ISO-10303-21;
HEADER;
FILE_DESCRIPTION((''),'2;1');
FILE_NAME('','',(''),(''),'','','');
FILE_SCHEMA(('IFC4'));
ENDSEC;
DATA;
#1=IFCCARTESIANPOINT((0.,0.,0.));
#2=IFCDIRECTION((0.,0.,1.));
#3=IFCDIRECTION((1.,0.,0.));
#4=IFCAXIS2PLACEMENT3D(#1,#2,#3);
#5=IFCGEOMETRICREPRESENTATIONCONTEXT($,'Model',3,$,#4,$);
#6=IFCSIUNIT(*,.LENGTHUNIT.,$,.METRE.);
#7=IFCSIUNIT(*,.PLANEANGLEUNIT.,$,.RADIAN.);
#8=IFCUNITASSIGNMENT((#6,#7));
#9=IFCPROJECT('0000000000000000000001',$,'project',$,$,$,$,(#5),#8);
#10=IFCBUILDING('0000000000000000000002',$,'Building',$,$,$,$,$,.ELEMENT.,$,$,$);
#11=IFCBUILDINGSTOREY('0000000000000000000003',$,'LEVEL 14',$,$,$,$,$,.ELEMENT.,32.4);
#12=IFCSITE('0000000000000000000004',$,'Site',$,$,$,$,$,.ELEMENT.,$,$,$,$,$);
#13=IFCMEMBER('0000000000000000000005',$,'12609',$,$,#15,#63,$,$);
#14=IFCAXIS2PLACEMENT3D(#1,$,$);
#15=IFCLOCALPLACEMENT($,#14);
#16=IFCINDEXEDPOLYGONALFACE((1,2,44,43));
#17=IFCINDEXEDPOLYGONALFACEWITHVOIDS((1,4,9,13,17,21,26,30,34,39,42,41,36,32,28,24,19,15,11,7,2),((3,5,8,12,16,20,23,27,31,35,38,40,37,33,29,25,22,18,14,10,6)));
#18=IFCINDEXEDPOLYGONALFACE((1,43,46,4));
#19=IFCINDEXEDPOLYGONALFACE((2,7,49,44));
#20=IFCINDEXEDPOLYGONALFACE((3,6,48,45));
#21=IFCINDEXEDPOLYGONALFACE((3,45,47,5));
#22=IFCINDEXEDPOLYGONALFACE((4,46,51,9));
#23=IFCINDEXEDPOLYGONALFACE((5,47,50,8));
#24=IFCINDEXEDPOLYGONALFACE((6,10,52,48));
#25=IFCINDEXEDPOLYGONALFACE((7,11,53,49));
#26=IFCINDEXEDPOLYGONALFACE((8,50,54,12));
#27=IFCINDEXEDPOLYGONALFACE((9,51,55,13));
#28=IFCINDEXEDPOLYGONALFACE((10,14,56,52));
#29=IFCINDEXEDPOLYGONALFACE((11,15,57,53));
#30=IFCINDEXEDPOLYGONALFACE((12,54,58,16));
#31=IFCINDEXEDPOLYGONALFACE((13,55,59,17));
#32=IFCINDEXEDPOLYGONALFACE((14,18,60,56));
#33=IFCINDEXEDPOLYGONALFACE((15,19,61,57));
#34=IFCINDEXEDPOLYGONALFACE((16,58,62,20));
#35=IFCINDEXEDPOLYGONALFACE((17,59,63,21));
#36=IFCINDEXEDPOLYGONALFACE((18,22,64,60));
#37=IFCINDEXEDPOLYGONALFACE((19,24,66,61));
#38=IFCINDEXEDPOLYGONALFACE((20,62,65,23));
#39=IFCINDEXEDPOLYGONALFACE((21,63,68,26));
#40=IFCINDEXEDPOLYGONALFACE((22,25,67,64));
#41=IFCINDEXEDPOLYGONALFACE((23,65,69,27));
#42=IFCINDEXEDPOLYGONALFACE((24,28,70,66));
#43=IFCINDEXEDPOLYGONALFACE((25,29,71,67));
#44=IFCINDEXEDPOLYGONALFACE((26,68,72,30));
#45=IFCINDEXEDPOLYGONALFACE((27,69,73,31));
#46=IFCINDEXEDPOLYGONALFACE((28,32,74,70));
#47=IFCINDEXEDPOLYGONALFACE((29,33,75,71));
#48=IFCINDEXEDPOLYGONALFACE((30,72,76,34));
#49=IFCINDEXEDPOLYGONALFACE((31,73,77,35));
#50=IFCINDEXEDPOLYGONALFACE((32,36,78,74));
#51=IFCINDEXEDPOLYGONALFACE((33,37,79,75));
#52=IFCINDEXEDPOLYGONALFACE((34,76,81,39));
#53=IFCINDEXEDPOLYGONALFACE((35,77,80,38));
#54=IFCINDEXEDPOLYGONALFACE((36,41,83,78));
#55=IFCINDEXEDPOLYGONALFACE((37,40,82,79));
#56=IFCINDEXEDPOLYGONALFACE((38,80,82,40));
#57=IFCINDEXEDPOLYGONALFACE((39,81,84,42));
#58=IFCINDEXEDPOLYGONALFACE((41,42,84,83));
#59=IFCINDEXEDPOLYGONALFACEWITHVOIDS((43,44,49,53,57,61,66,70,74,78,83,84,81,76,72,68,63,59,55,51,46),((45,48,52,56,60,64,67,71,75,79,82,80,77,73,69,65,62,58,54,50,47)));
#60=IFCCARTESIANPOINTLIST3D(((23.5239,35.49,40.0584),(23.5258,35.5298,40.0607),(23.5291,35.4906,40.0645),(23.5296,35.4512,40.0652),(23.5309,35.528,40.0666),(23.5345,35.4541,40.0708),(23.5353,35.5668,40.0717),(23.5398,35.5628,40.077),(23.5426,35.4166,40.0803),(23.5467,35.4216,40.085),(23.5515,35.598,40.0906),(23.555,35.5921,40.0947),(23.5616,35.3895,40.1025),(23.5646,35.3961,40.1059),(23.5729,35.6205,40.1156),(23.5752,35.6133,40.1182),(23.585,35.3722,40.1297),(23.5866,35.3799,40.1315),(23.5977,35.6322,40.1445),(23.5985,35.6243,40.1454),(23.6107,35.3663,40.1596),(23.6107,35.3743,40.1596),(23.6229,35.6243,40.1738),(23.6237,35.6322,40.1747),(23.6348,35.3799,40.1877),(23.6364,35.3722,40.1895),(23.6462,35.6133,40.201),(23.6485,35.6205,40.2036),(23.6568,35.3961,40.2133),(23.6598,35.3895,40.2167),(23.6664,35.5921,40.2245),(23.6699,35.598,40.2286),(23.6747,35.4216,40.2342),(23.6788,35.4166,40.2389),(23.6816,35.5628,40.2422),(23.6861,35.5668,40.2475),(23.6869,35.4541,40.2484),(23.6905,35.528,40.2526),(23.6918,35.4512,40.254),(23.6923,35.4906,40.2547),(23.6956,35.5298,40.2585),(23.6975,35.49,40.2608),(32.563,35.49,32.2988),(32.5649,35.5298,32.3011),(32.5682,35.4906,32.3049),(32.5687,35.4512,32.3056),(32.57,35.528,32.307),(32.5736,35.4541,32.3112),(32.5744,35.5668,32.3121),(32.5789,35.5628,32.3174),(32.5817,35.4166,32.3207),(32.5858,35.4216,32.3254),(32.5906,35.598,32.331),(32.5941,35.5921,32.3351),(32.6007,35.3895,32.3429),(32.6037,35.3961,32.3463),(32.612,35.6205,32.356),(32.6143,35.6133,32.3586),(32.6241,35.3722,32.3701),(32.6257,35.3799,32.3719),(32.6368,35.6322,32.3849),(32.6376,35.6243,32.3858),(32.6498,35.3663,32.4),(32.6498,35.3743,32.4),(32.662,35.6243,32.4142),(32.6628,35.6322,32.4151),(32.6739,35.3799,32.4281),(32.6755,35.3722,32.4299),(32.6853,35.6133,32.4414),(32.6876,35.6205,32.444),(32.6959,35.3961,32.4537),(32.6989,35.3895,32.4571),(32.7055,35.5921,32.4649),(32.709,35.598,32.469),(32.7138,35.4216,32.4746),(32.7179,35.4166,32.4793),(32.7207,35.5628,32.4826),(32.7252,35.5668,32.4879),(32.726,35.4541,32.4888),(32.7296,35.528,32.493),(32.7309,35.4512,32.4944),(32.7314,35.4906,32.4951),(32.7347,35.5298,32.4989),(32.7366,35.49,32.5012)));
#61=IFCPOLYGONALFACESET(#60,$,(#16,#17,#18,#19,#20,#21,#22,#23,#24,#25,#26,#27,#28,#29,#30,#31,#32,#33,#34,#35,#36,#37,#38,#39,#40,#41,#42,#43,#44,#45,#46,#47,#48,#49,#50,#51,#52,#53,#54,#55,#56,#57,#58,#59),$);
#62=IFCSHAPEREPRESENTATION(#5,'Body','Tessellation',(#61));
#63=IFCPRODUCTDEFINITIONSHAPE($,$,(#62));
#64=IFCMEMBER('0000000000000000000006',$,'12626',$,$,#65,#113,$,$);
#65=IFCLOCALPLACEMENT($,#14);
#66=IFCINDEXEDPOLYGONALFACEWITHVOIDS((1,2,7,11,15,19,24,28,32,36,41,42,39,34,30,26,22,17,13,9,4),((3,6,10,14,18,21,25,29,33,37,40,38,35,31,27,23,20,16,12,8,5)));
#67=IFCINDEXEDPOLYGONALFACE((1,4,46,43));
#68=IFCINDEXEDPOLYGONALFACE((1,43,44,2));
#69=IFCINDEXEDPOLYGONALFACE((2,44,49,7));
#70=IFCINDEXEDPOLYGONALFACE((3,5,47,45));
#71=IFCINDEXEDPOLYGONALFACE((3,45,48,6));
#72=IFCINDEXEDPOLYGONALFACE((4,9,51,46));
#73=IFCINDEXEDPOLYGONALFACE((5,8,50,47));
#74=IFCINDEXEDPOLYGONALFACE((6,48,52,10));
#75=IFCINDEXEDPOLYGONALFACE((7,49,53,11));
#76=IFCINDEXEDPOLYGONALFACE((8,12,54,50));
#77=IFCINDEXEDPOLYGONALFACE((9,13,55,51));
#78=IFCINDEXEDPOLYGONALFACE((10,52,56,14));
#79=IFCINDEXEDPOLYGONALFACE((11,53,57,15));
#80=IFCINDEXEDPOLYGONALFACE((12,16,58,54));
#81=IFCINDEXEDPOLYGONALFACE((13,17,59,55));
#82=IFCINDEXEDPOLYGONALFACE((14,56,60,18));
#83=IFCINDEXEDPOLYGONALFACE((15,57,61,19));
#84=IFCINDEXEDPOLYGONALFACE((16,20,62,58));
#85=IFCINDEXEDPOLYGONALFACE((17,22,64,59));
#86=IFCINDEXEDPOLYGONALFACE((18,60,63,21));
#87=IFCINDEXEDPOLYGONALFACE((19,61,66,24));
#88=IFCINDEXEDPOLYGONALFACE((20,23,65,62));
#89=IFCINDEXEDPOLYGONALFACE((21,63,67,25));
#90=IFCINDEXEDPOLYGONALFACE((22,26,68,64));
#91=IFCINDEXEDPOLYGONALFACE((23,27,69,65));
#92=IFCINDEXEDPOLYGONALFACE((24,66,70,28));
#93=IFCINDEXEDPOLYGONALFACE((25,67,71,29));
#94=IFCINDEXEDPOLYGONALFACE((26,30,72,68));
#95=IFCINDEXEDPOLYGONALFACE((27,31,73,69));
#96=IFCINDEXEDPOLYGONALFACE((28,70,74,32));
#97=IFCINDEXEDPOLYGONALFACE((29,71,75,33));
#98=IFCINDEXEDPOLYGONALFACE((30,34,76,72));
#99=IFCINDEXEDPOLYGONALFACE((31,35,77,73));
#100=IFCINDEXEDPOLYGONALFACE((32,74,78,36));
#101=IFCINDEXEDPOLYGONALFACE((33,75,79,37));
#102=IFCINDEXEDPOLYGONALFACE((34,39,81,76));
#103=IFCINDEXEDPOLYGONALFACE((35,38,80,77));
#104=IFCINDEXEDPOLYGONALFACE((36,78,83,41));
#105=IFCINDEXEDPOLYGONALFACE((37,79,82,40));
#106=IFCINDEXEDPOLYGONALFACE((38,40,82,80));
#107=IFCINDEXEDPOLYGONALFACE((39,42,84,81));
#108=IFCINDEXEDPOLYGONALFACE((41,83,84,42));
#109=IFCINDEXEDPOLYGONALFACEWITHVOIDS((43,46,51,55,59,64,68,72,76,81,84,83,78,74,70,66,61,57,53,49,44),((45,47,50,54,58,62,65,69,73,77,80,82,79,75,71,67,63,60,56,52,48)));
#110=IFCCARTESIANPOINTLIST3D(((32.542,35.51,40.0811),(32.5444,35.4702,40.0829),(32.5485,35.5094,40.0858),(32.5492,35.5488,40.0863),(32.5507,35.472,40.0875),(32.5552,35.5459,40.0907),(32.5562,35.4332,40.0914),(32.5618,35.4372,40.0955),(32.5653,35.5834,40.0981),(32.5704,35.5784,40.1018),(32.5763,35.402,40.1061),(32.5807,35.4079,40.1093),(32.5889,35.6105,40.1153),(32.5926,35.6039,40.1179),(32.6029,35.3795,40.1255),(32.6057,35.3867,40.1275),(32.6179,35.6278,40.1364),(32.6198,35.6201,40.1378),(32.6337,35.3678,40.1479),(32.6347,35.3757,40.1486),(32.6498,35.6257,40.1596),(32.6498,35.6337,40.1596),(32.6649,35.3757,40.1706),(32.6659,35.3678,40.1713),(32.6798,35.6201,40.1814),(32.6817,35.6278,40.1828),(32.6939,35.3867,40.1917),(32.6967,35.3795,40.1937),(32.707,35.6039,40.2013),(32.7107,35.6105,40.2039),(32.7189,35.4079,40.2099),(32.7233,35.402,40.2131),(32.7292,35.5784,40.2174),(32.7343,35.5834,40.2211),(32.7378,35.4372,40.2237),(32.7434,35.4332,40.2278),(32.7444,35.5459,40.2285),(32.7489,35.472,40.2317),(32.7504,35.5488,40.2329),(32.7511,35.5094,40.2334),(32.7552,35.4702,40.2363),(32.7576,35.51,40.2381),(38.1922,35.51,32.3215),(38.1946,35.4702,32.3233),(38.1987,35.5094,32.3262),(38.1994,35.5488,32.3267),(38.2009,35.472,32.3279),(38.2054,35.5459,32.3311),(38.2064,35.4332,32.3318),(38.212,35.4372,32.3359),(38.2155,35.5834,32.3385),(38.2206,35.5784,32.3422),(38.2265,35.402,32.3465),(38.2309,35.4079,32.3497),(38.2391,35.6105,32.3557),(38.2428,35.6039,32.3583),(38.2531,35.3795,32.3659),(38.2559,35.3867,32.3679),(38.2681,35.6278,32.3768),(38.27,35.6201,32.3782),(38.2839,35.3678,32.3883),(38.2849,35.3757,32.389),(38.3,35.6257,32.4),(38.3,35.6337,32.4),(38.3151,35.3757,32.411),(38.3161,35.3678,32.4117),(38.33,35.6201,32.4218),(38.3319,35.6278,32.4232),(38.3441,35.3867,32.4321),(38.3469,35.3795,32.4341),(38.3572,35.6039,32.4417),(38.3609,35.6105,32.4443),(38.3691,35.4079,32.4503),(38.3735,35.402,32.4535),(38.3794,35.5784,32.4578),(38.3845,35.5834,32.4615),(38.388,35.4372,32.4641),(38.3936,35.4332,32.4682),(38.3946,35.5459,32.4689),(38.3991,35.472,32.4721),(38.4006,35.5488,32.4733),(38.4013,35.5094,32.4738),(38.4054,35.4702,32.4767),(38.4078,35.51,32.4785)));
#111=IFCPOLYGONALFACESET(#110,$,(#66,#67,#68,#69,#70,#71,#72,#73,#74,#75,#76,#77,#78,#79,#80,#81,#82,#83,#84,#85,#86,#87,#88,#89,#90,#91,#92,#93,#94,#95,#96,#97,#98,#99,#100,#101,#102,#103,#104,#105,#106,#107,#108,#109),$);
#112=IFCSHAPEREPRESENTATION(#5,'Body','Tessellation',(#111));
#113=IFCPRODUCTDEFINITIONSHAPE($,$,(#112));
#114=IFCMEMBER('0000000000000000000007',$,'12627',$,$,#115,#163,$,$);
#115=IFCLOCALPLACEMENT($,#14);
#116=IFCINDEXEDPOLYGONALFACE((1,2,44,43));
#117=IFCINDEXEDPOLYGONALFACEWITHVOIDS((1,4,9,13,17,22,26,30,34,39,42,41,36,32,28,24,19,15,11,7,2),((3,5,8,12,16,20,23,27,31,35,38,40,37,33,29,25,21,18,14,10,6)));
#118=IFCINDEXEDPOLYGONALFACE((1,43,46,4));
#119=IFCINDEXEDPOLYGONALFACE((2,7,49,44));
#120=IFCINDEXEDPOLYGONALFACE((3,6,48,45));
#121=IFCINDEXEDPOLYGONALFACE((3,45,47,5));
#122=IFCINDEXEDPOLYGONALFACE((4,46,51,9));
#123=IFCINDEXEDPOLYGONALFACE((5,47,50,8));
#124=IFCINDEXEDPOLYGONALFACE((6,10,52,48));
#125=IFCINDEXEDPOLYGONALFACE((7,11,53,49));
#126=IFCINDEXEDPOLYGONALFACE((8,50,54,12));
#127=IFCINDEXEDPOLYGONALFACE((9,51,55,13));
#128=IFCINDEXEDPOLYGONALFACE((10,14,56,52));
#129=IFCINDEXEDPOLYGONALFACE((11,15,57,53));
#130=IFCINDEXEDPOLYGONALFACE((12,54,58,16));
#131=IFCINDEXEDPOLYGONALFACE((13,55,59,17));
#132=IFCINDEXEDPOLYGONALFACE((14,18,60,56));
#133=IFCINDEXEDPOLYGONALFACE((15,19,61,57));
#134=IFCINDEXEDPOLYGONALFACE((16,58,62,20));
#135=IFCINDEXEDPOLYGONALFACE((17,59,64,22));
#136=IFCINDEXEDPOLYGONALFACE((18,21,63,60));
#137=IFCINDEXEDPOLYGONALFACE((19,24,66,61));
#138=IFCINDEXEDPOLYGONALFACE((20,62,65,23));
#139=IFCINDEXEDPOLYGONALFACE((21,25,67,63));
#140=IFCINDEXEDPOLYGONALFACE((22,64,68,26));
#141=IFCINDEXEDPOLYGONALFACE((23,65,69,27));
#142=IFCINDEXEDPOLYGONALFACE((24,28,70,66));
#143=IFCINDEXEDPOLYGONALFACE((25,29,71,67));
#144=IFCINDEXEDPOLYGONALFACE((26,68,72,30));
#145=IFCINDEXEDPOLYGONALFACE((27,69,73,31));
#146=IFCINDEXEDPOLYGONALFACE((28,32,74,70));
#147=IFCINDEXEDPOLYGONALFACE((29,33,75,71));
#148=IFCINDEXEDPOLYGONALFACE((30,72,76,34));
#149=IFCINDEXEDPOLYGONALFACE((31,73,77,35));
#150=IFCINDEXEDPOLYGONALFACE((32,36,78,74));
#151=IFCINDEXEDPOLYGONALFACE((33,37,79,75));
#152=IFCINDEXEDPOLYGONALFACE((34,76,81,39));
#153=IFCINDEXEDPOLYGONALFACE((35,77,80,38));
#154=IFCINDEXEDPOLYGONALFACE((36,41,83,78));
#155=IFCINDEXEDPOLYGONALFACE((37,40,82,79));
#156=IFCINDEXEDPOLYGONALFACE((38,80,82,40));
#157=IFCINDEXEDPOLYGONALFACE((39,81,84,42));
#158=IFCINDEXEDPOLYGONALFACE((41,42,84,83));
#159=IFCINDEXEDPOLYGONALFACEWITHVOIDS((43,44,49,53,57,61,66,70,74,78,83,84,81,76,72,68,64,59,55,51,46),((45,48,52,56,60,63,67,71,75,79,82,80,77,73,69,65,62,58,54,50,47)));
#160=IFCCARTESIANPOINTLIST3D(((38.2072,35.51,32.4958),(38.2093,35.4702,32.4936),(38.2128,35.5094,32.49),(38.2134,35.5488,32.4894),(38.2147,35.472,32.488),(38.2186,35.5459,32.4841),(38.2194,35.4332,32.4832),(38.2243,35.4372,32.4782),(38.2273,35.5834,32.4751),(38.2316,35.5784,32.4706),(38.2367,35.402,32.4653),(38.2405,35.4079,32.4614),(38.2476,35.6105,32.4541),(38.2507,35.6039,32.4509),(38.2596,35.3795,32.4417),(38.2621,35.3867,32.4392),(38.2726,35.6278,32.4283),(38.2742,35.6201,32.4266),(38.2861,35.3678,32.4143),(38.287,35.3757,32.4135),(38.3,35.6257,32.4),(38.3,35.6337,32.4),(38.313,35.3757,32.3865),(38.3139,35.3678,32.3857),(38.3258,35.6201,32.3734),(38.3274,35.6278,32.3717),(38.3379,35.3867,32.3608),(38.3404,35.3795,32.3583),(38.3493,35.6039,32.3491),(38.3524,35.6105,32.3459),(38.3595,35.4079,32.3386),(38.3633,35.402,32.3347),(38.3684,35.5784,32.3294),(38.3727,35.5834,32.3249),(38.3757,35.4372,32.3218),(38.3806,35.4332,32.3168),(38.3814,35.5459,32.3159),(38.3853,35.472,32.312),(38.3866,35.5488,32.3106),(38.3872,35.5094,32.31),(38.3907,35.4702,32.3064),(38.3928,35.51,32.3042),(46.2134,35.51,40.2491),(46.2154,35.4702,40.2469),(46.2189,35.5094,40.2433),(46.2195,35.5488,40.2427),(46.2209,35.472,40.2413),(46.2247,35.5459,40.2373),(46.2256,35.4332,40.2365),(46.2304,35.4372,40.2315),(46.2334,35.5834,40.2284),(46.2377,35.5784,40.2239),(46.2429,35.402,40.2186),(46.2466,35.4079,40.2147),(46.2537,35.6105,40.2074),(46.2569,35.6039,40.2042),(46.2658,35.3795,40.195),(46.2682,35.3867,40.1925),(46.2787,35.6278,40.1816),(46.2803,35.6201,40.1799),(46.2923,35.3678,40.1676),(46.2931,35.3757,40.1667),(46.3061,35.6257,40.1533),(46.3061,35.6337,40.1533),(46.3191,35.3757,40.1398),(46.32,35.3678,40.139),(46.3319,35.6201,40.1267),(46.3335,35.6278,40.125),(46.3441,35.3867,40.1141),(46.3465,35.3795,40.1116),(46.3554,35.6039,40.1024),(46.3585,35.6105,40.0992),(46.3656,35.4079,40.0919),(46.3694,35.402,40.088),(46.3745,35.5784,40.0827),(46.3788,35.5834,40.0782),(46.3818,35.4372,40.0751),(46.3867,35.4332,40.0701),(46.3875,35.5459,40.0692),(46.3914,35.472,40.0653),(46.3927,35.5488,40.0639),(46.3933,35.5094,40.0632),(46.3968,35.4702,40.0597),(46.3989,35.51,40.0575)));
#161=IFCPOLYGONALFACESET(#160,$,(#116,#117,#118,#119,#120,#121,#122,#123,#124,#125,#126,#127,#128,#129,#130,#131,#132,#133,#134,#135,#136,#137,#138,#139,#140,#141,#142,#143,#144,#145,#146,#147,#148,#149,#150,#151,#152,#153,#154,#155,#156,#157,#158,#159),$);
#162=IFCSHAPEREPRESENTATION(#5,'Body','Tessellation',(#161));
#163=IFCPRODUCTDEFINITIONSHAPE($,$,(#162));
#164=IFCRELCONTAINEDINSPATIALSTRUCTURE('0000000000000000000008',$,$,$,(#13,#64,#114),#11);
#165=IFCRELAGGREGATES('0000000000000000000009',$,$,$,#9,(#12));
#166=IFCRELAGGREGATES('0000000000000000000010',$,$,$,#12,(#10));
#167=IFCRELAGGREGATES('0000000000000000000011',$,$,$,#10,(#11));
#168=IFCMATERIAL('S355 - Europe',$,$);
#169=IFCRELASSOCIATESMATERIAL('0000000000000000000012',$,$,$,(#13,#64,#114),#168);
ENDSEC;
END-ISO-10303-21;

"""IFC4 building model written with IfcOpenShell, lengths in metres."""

from ifc_helpers import new_model, si_unit, frame, origin_with_axes, origin_2d_with_axis, place, context, project, spatial, hollow_circle, extrude, material, material_profile, profile_set, profile_usage, element, save


model = new_model("IFC4")

# Units and contexts
model_context = context("Model", 3, world=origin_with_axes())
ifc_project = project(units=[si_unit("LENGTHUNIT", "METRE"), si_unit("PLANEANGLEUNIT", "RADIAN")], contexts=[model_context])

# Site, building, storey
site = spatial("IfcSite", under=ifc_project, Name="Site", CompositionType="ELEMENT")
building = spatial("IfcBuilding", under=site, Name="Building", CompositionType="ELEMENT")
storey = spatial("IfcBuildingStorey", under=building, Name="LEVEL 14", CompositionType="ELEMENT", Elevation=32.4)

# Shared definitions
ifc_material = material(Name="S355 - Europe")

# Members
ifc_material_profile_1 = material_profile(ifc_material, hollow_circle(Radius=0.1337, WallThickness=0.008, at=origin_2d_with_axis()))
ifc_profile_set_1 = profile_set([ifc_material_profile_1])
ifc_profile_usage_1 = profile_usage(ifc_profile_set_1, cardinal=10)
member_1_placement = place(None, frame((32.6498, 35.5, 32.4), z_axis=(-0.758767, 0.0, 0.651362), x_axis=(0.0, -1.0, 0.0)))
element("IfcMember", 1, at=member_1_placement, inside=storey, material=ifc_profile_usage_1, Name="12609", context=model_context, shape_type="SweptSolid", body=[
    extrude(hollow_circle(Radius=0.1337, WallThickness=0.008, at=origin_2d_with_axis()), origin_with_axes(), (0.0, 0.0, 1.0), 11.9129),
])
ifc_material_profile_2 = material_profile(ifc_material, hollow_circle(Radius=0.1337, WallThickness=0.008, at=origin_2d_with_axis()))
ifc_profile_set_2 = profile_set([ifc_material_profile_2])
ifc_profile_usage_2 = profile_usage(ifc_profile_set_2, cardinal=10)
member_2_placement = place(None, frame((32.6498, 35.5, 40.1596), z_axis=(0.588639, 0.0, -0.808396), x_axis=(0.0, 1.0, 0.0)))
element("IfcMember", 2, at=member_2_placement, inside=storey, material=ifc_profile_usage_2, Name="12626", context=model_context, shape_type="SweptSolid", body=[
    extrude(hollow_circle(Radius=0.1337, WallThickness=0.008, at=origin_2d_with_axis()), origin_with_axes(), (0.0, 0.0, 1.0), 9.5988),
])
ifc_material_profile_3 = material_profile(ifc_material, hollow_circle(Radius=0.1337, WallThickness=0.008, at=origin_2d_with_axis()))
ifc_profile_set_3 = profile_set([ifc_material_profile_3])
ifc_profile_usage_3 = profile_usage(ifc_profile_set_3, cardinal=10)
member_3_placement = place(None, frame((38.3, 35.5, 32.4), z_axis=(0.718358, 0.0, 0.695673), x_axis=(0.0, 1.0, 0.0)))
element("IfcMember", 3, at=member_3_placement, inside=storey, material=ifc_profile_usage_3, Name="12627", context=model_context, shape_type="SweptSolid", body=[
    extrude(hollow_circle(Radius=0.1337, WallThickness=0.008, at=origin_2d_with_axis()), origin_with_axes(), (0.0, 0.0, 1.0), 11.145),
])

save(model, "model.ifc")
